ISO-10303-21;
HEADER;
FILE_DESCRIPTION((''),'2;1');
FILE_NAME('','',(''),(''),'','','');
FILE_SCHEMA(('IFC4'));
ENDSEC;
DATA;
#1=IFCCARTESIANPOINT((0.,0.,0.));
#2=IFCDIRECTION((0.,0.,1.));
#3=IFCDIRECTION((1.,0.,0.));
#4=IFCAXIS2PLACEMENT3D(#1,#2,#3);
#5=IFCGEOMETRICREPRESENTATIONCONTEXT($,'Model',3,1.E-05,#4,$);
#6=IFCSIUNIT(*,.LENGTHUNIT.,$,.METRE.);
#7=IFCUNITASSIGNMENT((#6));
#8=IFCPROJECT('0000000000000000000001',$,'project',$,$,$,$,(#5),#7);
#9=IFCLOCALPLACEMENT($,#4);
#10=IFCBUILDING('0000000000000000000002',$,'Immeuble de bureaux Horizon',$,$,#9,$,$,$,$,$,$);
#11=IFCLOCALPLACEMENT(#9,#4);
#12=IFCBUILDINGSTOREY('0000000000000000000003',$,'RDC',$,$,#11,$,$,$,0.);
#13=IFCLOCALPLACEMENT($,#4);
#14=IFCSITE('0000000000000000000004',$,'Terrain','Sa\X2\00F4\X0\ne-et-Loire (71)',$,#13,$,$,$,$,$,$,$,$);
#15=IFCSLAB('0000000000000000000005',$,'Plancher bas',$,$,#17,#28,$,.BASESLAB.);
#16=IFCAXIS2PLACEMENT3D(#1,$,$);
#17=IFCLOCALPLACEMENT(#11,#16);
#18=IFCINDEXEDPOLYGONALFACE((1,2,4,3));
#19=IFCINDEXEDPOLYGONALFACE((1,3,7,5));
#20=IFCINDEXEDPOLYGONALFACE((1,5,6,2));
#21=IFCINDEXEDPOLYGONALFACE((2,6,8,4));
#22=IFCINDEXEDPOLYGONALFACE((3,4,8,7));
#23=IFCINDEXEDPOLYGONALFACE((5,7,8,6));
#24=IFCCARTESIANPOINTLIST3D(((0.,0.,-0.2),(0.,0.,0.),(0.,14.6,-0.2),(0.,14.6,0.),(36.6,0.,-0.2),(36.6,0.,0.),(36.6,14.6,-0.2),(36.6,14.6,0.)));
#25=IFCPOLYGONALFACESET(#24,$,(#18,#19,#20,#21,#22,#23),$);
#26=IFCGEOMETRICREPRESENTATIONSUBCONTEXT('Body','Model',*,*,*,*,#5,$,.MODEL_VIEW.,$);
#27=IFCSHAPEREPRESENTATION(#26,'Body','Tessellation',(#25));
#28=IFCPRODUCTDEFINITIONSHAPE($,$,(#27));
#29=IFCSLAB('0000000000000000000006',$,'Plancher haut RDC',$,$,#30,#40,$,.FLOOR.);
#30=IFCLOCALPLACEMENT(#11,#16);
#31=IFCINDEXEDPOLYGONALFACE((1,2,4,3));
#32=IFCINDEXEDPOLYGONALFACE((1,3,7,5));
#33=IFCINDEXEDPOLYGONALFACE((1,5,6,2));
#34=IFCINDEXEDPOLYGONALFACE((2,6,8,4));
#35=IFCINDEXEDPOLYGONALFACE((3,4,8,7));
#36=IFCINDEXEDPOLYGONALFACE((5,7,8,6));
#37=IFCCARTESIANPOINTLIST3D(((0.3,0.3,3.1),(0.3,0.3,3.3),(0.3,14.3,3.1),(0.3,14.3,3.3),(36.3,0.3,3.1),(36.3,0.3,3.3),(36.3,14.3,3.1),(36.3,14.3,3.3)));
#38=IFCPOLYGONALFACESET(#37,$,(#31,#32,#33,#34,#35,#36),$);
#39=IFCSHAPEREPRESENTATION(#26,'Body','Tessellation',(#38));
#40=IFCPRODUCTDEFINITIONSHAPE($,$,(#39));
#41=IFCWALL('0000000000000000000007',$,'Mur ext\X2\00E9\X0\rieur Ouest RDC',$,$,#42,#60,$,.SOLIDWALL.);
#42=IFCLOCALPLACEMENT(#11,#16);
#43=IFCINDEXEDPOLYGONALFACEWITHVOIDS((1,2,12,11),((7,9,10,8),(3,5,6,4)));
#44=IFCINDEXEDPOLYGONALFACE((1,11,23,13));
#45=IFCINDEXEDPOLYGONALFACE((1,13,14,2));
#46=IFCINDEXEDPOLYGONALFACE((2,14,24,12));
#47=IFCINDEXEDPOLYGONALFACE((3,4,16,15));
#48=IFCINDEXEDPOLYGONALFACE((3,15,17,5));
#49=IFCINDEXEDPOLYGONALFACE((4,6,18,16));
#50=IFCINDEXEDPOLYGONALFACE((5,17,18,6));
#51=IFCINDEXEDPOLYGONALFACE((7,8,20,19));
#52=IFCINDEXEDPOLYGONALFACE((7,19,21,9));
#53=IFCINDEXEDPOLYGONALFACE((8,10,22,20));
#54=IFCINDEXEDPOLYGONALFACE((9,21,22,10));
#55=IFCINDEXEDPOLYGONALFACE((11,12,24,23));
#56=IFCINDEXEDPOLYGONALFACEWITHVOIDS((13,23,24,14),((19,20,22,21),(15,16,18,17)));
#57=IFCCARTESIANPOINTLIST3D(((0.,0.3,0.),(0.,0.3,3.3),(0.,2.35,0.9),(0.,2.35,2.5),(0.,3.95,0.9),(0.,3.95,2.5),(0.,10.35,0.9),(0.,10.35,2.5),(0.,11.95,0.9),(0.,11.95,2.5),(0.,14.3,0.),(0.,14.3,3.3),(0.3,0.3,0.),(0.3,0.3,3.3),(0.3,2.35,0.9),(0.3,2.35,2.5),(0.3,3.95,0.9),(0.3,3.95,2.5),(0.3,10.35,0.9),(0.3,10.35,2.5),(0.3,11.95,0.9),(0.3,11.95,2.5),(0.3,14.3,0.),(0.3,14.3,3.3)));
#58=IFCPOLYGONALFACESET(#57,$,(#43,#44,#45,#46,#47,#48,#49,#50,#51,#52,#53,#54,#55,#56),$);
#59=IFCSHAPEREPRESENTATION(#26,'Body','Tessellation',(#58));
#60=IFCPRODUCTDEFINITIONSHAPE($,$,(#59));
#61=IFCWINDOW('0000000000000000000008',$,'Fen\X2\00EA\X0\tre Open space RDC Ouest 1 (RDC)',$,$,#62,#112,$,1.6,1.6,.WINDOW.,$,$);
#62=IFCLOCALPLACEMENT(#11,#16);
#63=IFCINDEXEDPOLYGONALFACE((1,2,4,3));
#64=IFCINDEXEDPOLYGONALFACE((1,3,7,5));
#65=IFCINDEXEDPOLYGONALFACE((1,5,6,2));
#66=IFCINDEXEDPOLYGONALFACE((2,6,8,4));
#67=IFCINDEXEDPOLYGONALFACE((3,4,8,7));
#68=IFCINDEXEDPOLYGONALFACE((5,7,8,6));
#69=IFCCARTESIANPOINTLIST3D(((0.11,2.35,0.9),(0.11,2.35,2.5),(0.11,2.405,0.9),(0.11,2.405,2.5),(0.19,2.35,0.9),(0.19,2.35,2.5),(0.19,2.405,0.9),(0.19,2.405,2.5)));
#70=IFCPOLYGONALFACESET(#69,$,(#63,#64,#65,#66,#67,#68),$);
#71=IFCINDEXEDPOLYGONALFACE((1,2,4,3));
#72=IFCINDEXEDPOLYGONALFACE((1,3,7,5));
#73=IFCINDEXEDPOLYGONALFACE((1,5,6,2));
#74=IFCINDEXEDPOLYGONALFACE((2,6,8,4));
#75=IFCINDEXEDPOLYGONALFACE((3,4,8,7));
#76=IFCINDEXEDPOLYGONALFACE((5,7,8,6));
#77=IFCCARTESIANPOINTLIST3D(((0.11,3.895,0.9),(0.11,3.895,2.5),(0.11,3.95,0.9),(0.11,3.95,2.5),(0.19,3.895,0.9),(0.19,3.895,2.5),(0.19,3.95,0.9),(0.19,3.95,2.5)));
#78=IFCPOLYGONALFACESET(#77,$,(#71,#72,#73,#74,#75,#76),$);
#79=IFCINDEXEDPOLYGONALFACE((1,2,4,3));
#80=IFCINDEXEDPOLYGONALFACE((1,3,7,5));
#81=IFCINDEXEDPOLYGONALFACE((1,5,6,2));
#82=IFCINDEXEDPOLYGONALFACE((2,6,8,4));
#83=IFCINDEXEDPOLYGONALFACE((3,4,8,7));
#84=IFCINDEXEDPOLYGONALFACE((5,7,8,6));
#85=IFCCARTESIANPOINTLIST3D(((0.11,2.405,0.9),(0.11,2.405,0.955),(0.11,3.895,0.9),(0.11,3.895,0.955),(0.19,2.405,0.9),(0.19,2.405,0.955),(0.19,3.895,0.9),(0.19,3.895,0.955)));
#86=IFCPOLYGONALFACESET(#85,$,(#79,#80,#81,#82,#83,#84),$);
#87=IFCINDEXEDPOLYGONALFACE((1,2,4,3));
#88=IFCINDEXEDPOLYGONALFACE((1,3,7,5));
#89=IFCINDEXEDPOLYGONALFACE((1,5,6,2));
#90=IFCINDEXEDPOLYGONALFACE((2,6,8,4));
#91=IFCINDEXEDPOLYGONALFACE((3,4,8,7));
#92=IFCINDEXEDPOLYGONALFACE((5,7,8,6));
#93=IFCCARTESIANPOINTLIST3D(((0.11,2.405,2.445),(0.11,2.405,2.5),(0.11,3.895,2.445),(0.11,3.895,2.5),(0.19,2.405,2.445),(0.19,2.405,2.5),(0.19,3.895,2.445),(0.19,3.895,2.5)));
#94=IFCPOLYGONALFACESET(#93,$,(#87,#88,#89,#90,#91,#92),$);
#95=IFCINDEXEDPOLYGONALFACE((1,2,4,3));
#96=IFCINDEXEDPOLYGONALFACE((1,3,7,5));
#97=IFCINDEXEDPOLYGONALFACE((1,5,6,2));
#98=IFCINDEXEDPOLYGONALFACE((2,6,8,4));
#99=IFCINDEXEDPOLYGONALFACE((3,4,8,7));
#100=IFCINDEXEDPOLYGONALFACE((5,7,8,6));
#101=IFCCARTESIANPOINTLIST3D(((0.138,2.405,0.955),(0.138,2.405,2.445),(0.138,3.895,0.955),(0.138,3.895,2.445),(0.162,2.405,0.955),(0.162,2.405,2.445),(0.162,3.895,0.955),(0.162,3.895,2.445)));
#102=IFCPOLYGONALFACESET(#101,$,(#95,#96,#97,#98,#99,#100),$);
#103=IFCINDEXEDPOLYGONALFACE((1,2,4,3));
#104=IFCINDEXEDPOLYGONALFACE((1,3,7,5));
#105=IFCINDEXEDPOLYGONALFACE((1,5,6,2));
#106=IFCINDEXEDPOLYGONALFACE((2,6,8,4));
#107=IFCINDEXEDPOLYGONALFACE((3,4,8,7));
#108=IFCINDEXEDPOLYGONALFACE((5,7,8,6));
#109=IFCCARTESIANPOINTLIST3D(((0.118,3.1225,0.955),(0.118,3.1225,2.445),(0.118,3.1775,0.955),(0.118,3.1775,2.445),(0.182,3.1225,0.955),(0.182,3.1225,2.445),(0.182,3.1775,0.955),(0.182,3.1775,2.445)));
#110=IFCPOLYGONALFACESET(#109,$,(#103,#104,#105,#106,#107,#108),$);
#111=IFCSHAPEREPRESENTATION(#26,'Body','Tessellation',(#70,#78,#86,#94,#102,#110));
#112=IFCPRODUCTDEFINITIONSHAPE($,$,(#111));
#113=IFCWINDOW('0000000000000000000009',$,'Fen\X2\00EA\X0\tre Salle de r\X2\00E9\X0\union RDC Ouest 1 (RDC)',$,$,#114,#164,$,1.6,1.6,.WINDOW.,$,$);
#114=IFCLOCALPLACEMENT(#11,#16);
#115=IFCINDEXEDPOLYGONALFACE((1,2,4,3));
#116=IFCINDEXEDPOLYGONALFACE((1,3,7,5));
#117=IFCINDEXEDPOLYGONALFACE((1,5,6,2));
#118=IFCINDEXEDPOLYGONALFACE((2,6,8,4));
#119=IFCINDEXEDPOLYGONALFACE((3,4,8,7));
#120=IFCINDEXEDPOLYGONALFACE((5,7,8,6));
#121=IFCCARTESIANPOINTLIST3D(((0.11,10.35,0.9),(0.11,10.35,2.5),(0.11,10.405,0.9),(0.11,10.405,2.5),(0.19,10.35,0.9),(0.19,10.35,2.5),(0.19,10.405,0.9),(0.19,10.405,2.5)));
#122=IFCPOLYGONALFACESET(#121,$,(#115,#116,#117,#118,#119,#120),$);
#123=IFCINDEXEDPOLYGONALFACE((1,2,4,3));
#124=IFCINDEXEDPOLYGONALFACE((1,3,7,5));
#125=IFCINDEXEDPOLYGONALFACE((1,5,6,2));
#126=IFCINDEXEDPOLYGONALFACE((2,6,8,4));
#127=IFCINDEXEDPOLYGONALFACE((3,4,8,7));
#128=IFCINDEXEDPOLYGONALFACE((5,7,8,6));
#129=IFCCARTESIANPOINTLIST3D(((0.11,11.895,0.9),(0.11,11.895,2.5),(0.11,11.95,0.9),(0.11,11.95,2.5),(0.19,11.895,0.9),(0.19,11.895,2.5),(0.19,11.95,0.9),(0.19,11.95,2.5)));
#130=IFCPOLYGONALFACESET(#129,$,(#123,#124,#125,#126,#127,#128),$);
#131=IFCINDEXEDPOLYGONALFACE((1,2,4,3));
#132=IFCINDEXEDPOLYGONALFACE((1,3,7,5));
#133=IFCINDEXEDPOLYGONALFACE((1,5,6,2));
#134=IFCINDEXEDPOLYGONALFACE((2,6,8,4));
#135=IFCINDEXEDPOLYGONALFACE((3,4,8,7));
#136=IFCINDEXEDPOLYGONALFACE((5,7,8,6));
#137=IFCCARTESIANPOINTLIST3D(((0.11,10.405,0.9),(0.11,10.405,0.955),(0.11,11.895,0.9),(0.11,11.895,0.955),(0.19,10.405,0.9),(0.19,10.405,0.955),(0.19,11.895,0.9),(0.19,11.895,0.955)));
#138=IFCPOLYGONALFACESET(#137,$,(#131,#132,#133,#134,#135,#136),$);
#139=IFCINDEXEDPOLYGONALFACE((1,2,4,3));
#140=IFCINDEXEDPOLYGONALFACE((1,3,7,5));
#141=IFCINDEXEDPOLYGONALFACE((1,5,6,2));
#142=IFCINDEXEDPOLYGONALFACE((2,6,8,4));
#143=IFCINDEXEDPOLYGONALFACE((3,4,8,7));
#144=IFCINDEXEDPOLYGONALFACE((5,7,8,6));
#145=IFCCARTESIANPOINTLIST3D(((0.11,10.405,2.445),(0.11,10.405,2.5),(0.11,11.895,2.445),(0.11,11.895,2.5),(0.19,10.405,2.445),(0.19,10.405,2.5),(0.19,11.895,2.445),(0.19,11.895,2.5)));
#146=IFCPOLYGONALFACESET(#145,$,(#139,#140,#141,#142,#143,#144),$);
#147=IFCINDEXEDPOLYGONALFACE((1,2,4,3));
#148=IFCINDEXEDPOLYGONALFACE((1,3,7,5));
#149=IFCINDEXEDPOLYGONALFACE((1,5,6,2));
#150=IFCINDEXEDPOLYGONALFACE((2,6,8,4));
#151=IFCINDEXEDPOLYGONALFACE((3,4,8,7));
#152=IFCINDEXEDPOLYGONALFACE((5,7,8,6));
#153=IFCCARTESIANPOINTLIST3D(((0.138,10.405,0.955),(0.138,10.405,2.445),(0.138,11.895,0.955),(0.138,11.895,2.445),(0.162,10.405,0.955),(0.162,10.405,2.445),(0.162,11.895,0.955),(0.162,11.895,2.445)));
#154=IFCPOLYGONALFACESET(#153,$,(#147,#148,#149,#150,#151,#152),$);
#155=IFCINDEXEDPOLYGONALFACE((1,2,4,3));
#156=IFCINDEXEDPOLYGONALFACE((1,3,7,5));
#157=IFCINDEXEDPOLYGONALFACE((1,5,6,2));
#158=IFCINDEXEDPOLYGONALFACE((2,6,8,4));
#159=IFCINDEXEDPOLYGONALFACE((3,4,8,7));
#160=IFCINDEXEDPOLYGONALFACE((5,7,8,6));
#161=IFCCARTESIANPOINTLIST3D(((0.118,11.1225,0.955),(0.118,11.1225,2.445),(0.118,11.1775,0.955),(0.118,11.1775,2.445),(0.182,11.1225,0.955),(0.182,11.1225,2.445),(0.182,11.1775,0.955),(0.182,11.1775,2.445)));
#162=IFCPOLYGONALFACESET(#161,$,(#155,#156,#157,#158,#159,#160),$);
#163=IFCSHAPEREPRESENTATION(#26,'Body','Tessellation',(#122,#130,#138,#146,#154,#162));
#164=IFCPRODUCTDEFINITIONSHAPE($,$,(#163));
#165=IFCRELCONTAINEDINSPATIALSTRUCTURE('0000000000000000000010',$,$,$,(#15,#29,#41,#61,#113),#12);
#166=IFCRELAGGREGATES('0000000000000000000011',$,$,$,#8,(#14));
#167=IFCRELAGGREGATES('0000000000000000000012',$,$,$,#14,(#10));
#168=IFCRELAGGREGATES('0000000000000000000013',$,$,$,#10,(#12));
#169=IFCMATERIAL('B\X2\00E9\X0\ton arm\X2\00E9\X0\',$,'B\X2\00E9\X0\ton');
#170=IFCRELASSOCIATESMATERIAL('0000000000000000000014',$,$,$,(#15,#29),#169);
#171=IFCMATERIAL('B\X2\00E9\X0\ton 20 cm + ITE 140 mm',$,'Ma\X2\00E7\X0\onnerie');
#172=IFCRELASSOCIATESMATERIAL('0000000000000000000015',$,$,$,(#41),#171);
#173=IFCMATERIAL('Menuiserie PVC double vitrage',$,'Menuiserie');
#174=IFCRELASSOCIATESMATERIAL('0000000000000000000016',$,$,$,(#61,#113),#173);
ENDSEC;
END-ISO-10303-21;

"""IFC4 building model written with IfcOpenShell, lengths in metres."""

from ifc_helpers import new_model, si_unit, frame, frame_2d, origin_with_axes, place, context, subcontext, project, spatial, rectangle, extrude, material, element, fill, save


model = new_model("IFC4")

# Units and contexts
model_context = context("Model", 3, precision=1e-05, world=origin_with_axes())
body_context = subcontext(model_context, "Body", "Model", "MODEL_VIEW")
ifc_project = project(units=[si_unit("LENGTHUNIT", "METRE")], contexts=[model_context])

# Site, building, storey
site_placement = place(None, origin_with_axes())
site = spatial("IfcSite", under=ifc_project, at=site_placement, Name="Terrain", Description="Saône-et-Loire (71)")
building_placement = place(None, origin_with_axes())
building = spatial("IfcBuilding", under=site, at=building_placement, Name="Immeuble de bureaux Horizon")
storey_placement = place(building_placement, origin_with_axes())
storey = spatial("IfcBuildingStorey", under=building, at=storey_placement, Name="RDC", Elevation=0.0)

# Slabs
ifc_material_1 = material(Name="Béton armé", Category="Béton")
slab_1_placement = place(storey_placement, frame((0.0, 0.0, -0.2), z_axis=(0.0, 0.0, 1.0), x_axis=(1.0, 0.0, 0.0)))
element("IfcSlab", 1, at=slab_1_placement, inside=storey, material=ifc_material_1, Name="Plancher bas", PredefinedType="BASESLAB", context=body_context, shape_type="SweptSolid", body=[
    extrude(rectangle(XDim=36.6, YDim=14.6, at=frame_2d((18.3, 7.3))), origin_with_axes(), (0.0, 0.0, 1.0), 0.2),
])
slab_2_placement = place(storey_placement, frame((0.3, 0.3, 3.1), z_axis=(0.0, 0.0, 1.0), x_axis=(1.0, 0.0, 0.0)))
element("IfcSlab", 2, at=slab_2_placement, inside=storey, material=ifc_material_1, Name="Plancher haut RDC", PredefinedType="FLOOR", context=body_context, shape_type="SweptSolid", body=[
    extrude(rectangle(XDim=36.0, YDim=14.0, at=frame_2d((18.0, 7.0))), origin_with_axes(), (0.0, 0.0, 1.0), 0.2),
])

# Wall, openings, windows
ifc_material_2 = material(Name="Béton 20 cm + ITE 140 mm", Category="Maçonnerie")
ifc_material_3 = material(Name="Menuiserie PVC double vitrage", Category="Menuiserie")
wall_1_placement = place(storey_placement, frame((0.0, 0.3, 0.0), z_axis=(0.0, 0.0, 1.0), x_axis=(1.0, 0.0, 0.0)))
wall_1 = element("IfcWall", 3, at=wall_1_placement, inside=storey, material=ifc_material_2, Name="Mur extérieur Ouest RDC", PredefinedType="SOLIDWALL", context=body_context, shape_type="SweptSolid", body=[
    extrude(rectangle(XDim=0.3, YDim=14.0, at=frame_2d((0.15, 7.0))), origin_with_axes(), (0.0, 0.0, 1.0), 3.3),
])
opening_1_placement = place(storey_placement, frame((-0.05, 2.35, 0.9), z_axis=(0.0, 0.0, 1.0), x_axis=(1.0, 0.0, 0.0)))
opening_1 = element("IfcOpeningElement", 4, at=opening_1_placement, cuts=wall_1, context=body_context, shape_type="SweptSolid", body=[
    extrude(rectangle(XDim=0.4, YDim=1.6, at=frame_2d((0.2, 0.8))), origin_with_axes(), (0.0, 0.0, 1.0), 1.6),
])
opening_2_placement = place(storey_placement, frame((-0.05, 10.35, 0.9), z_axis=(0.0, 0.0, 1.0), x_axis=(1.0, 0.0, 0.0)))
opening_2 = element("IfcOpeningElement", 5, at=opening_2_placement, cuts=wall_1, context=body_context, shape_type="SweptSolid", body=[
    extrude(rectangle(XDim=0.4, YDim=1.6, at=frame_2d((0.2, 0.8))), origin_with_axes(), (0.0, 0.0, 1.0), 1.6),
])
window_1_placement = place(storey_placement, frame((0.11, 2.35, 0.9), z_axis=(0.0, 0.0, 1.0), x_axis=(1.0, 0.0, 0.0)))
window_1 = element("IfcWindow", 6, at=window_1_placement, inside=storey, material=ifc_material_3, Name="Fenêtre Open space RDC Ouest 1 (RDC)", OverallHeight=1.6, OverallWidth=1.6, PredefinedType="WINDOW", context=body_context, shape_type="SweptSolid", body=[
    extrude(rectangle(XDim=0.08, YDim=0.055, at=frame_2d((0.04, 0.0275))), origin_with_axes(), (0.0, 0.0, 1.0), 1.6),
    extrude(rectangle(XDim=0.08, YDim=0.055, at=frame_2d((0.04, 0.0275))), frame((0.0, 1.545, 0.0), z_axis=(0.0, 0.0, 1.0), x_axis=(1.0, 0.0, 0.0)), (0.0, 0.0, 1.0), 1.6),
    extrude(rectangle(XDim=0.08, YDim=1.49, at=frame_2d((0.04, 0.745))), frame((0.0, 0.055, 0.0), z_axis=(0.0, 0.0, 1.0), x_axis=(1.0, 0.0, 0.0)), (0.0, 0.0, 1.0), 0.055),
    extrude(rectangle(XDim=0.08, YDim=1.49, at=frame_2d((0.04, 0.745))), frame((0.0, 0.055, 1.545), z_axis=(0.0, 0.0, 1.0), x_axis=(1.0, 0.0, 0.0)), (0.0, 0.0, 1.0), 0.055),
    extrude(rectangle(XDim=0.024, YDim=1.49, at=frame_2d((0.012, 0.745))), frame((0.028, 0.055, 0.055), z_axis=(0.0, 0.0, 1.0), x_axis=(1.0, 0.0, 0.0)), (0.0, 0.0, 1.0), 1.49),
    extrude(rectangle(XDim=0.064, YDim=0.055, at=frame_2d((0.032, 0.0275))), frame((0.008, 0.7725, 0.055), z_axis=(0.0, 0.0, 1.0), x_axis=(1.0, 0.0, 0.0)), (0.0, 0.0, 1.0), 1.49),
])
fill(opening_1, window_1)
window_2_placement = place(storey_placement, frame((0.11, 10.35, 0.9), z_axis=(0.0, 0.0, 1.0), x_axis=(1.0, 0.0, 0.0)))
window_2 = element("IfcWindow", 7, at=window_2_placement, inside=storey, material=ifc_material_3, Name="Fenêtre Salle de réunion RDC Ouest 1 (RDC)", OverallHeight=1.6, OverallWidth=1.6, PredefinedType="WINDOW", context=body_context, shape_type="SweptSolid", body=[
    extrude(rectangle(XDim=0.08, YDim=0.055, at=frame_2d((0.04, 0.0275))), origin_with_axes(), (0.0, 0.0, 1.0), 1.6),
    extrude(rectangle(XDim=0.08, YDim=0.055, at=frame_2d((0.04, 0.0275))), frame((0.0, 1.545, 0.0), z_axis=(0.0, 0.0, 1.0), x_axis=(1.0, 0.0, 0.0)), (0.0, 0.0, 1.0), 1.6),
    extrude(rectangle(XDim=0.08, YDim=1.49, at=frame_2d((0.04, 0.745))), frame((0.0, 0.055, 0.0), z_axis=(0.0, 0.0, 1.0), x_axis=(1.0, 0.0, 0.0)), (0.0, 0.0, 1.0), 0.055),
    extrude(rectangle(XDim=0.08, YDim=1.49, at=frame_2d((0.04, 0.745))), frame((0.0, 0.055, 1.545), z_axis=(0.0, 0.0, 1.0), x_axis=(1.0, 0.0, 0.0)), (0.0, 0.0, 1.0), 0.055),
    extrude(rectangle(XDim=0.024, YDim=1.49, at=frame_2d((0.012, 0.745))), frame((0.028, 0.055, 0.055), z_axis=(0.0, 0.0, 1.0), x_axis=(1.0, 0.0, 0.0)), (0.0, 0.0, 1.0), 1.49),
    extrude(rectangle(XDim=0.064, YDim=0.055, at=frame_2d((0.032, 0.0275))), frame((0.008, 0.7725, 0.055), z_axis=(0.0, 0.0, 1.0), x_axis=(1.0, 0.0, 0.0)), (0.0, 0.0, 1.0), 1.49),
])
fill(opening_2, window_2)

save(model, "model.ifc")
